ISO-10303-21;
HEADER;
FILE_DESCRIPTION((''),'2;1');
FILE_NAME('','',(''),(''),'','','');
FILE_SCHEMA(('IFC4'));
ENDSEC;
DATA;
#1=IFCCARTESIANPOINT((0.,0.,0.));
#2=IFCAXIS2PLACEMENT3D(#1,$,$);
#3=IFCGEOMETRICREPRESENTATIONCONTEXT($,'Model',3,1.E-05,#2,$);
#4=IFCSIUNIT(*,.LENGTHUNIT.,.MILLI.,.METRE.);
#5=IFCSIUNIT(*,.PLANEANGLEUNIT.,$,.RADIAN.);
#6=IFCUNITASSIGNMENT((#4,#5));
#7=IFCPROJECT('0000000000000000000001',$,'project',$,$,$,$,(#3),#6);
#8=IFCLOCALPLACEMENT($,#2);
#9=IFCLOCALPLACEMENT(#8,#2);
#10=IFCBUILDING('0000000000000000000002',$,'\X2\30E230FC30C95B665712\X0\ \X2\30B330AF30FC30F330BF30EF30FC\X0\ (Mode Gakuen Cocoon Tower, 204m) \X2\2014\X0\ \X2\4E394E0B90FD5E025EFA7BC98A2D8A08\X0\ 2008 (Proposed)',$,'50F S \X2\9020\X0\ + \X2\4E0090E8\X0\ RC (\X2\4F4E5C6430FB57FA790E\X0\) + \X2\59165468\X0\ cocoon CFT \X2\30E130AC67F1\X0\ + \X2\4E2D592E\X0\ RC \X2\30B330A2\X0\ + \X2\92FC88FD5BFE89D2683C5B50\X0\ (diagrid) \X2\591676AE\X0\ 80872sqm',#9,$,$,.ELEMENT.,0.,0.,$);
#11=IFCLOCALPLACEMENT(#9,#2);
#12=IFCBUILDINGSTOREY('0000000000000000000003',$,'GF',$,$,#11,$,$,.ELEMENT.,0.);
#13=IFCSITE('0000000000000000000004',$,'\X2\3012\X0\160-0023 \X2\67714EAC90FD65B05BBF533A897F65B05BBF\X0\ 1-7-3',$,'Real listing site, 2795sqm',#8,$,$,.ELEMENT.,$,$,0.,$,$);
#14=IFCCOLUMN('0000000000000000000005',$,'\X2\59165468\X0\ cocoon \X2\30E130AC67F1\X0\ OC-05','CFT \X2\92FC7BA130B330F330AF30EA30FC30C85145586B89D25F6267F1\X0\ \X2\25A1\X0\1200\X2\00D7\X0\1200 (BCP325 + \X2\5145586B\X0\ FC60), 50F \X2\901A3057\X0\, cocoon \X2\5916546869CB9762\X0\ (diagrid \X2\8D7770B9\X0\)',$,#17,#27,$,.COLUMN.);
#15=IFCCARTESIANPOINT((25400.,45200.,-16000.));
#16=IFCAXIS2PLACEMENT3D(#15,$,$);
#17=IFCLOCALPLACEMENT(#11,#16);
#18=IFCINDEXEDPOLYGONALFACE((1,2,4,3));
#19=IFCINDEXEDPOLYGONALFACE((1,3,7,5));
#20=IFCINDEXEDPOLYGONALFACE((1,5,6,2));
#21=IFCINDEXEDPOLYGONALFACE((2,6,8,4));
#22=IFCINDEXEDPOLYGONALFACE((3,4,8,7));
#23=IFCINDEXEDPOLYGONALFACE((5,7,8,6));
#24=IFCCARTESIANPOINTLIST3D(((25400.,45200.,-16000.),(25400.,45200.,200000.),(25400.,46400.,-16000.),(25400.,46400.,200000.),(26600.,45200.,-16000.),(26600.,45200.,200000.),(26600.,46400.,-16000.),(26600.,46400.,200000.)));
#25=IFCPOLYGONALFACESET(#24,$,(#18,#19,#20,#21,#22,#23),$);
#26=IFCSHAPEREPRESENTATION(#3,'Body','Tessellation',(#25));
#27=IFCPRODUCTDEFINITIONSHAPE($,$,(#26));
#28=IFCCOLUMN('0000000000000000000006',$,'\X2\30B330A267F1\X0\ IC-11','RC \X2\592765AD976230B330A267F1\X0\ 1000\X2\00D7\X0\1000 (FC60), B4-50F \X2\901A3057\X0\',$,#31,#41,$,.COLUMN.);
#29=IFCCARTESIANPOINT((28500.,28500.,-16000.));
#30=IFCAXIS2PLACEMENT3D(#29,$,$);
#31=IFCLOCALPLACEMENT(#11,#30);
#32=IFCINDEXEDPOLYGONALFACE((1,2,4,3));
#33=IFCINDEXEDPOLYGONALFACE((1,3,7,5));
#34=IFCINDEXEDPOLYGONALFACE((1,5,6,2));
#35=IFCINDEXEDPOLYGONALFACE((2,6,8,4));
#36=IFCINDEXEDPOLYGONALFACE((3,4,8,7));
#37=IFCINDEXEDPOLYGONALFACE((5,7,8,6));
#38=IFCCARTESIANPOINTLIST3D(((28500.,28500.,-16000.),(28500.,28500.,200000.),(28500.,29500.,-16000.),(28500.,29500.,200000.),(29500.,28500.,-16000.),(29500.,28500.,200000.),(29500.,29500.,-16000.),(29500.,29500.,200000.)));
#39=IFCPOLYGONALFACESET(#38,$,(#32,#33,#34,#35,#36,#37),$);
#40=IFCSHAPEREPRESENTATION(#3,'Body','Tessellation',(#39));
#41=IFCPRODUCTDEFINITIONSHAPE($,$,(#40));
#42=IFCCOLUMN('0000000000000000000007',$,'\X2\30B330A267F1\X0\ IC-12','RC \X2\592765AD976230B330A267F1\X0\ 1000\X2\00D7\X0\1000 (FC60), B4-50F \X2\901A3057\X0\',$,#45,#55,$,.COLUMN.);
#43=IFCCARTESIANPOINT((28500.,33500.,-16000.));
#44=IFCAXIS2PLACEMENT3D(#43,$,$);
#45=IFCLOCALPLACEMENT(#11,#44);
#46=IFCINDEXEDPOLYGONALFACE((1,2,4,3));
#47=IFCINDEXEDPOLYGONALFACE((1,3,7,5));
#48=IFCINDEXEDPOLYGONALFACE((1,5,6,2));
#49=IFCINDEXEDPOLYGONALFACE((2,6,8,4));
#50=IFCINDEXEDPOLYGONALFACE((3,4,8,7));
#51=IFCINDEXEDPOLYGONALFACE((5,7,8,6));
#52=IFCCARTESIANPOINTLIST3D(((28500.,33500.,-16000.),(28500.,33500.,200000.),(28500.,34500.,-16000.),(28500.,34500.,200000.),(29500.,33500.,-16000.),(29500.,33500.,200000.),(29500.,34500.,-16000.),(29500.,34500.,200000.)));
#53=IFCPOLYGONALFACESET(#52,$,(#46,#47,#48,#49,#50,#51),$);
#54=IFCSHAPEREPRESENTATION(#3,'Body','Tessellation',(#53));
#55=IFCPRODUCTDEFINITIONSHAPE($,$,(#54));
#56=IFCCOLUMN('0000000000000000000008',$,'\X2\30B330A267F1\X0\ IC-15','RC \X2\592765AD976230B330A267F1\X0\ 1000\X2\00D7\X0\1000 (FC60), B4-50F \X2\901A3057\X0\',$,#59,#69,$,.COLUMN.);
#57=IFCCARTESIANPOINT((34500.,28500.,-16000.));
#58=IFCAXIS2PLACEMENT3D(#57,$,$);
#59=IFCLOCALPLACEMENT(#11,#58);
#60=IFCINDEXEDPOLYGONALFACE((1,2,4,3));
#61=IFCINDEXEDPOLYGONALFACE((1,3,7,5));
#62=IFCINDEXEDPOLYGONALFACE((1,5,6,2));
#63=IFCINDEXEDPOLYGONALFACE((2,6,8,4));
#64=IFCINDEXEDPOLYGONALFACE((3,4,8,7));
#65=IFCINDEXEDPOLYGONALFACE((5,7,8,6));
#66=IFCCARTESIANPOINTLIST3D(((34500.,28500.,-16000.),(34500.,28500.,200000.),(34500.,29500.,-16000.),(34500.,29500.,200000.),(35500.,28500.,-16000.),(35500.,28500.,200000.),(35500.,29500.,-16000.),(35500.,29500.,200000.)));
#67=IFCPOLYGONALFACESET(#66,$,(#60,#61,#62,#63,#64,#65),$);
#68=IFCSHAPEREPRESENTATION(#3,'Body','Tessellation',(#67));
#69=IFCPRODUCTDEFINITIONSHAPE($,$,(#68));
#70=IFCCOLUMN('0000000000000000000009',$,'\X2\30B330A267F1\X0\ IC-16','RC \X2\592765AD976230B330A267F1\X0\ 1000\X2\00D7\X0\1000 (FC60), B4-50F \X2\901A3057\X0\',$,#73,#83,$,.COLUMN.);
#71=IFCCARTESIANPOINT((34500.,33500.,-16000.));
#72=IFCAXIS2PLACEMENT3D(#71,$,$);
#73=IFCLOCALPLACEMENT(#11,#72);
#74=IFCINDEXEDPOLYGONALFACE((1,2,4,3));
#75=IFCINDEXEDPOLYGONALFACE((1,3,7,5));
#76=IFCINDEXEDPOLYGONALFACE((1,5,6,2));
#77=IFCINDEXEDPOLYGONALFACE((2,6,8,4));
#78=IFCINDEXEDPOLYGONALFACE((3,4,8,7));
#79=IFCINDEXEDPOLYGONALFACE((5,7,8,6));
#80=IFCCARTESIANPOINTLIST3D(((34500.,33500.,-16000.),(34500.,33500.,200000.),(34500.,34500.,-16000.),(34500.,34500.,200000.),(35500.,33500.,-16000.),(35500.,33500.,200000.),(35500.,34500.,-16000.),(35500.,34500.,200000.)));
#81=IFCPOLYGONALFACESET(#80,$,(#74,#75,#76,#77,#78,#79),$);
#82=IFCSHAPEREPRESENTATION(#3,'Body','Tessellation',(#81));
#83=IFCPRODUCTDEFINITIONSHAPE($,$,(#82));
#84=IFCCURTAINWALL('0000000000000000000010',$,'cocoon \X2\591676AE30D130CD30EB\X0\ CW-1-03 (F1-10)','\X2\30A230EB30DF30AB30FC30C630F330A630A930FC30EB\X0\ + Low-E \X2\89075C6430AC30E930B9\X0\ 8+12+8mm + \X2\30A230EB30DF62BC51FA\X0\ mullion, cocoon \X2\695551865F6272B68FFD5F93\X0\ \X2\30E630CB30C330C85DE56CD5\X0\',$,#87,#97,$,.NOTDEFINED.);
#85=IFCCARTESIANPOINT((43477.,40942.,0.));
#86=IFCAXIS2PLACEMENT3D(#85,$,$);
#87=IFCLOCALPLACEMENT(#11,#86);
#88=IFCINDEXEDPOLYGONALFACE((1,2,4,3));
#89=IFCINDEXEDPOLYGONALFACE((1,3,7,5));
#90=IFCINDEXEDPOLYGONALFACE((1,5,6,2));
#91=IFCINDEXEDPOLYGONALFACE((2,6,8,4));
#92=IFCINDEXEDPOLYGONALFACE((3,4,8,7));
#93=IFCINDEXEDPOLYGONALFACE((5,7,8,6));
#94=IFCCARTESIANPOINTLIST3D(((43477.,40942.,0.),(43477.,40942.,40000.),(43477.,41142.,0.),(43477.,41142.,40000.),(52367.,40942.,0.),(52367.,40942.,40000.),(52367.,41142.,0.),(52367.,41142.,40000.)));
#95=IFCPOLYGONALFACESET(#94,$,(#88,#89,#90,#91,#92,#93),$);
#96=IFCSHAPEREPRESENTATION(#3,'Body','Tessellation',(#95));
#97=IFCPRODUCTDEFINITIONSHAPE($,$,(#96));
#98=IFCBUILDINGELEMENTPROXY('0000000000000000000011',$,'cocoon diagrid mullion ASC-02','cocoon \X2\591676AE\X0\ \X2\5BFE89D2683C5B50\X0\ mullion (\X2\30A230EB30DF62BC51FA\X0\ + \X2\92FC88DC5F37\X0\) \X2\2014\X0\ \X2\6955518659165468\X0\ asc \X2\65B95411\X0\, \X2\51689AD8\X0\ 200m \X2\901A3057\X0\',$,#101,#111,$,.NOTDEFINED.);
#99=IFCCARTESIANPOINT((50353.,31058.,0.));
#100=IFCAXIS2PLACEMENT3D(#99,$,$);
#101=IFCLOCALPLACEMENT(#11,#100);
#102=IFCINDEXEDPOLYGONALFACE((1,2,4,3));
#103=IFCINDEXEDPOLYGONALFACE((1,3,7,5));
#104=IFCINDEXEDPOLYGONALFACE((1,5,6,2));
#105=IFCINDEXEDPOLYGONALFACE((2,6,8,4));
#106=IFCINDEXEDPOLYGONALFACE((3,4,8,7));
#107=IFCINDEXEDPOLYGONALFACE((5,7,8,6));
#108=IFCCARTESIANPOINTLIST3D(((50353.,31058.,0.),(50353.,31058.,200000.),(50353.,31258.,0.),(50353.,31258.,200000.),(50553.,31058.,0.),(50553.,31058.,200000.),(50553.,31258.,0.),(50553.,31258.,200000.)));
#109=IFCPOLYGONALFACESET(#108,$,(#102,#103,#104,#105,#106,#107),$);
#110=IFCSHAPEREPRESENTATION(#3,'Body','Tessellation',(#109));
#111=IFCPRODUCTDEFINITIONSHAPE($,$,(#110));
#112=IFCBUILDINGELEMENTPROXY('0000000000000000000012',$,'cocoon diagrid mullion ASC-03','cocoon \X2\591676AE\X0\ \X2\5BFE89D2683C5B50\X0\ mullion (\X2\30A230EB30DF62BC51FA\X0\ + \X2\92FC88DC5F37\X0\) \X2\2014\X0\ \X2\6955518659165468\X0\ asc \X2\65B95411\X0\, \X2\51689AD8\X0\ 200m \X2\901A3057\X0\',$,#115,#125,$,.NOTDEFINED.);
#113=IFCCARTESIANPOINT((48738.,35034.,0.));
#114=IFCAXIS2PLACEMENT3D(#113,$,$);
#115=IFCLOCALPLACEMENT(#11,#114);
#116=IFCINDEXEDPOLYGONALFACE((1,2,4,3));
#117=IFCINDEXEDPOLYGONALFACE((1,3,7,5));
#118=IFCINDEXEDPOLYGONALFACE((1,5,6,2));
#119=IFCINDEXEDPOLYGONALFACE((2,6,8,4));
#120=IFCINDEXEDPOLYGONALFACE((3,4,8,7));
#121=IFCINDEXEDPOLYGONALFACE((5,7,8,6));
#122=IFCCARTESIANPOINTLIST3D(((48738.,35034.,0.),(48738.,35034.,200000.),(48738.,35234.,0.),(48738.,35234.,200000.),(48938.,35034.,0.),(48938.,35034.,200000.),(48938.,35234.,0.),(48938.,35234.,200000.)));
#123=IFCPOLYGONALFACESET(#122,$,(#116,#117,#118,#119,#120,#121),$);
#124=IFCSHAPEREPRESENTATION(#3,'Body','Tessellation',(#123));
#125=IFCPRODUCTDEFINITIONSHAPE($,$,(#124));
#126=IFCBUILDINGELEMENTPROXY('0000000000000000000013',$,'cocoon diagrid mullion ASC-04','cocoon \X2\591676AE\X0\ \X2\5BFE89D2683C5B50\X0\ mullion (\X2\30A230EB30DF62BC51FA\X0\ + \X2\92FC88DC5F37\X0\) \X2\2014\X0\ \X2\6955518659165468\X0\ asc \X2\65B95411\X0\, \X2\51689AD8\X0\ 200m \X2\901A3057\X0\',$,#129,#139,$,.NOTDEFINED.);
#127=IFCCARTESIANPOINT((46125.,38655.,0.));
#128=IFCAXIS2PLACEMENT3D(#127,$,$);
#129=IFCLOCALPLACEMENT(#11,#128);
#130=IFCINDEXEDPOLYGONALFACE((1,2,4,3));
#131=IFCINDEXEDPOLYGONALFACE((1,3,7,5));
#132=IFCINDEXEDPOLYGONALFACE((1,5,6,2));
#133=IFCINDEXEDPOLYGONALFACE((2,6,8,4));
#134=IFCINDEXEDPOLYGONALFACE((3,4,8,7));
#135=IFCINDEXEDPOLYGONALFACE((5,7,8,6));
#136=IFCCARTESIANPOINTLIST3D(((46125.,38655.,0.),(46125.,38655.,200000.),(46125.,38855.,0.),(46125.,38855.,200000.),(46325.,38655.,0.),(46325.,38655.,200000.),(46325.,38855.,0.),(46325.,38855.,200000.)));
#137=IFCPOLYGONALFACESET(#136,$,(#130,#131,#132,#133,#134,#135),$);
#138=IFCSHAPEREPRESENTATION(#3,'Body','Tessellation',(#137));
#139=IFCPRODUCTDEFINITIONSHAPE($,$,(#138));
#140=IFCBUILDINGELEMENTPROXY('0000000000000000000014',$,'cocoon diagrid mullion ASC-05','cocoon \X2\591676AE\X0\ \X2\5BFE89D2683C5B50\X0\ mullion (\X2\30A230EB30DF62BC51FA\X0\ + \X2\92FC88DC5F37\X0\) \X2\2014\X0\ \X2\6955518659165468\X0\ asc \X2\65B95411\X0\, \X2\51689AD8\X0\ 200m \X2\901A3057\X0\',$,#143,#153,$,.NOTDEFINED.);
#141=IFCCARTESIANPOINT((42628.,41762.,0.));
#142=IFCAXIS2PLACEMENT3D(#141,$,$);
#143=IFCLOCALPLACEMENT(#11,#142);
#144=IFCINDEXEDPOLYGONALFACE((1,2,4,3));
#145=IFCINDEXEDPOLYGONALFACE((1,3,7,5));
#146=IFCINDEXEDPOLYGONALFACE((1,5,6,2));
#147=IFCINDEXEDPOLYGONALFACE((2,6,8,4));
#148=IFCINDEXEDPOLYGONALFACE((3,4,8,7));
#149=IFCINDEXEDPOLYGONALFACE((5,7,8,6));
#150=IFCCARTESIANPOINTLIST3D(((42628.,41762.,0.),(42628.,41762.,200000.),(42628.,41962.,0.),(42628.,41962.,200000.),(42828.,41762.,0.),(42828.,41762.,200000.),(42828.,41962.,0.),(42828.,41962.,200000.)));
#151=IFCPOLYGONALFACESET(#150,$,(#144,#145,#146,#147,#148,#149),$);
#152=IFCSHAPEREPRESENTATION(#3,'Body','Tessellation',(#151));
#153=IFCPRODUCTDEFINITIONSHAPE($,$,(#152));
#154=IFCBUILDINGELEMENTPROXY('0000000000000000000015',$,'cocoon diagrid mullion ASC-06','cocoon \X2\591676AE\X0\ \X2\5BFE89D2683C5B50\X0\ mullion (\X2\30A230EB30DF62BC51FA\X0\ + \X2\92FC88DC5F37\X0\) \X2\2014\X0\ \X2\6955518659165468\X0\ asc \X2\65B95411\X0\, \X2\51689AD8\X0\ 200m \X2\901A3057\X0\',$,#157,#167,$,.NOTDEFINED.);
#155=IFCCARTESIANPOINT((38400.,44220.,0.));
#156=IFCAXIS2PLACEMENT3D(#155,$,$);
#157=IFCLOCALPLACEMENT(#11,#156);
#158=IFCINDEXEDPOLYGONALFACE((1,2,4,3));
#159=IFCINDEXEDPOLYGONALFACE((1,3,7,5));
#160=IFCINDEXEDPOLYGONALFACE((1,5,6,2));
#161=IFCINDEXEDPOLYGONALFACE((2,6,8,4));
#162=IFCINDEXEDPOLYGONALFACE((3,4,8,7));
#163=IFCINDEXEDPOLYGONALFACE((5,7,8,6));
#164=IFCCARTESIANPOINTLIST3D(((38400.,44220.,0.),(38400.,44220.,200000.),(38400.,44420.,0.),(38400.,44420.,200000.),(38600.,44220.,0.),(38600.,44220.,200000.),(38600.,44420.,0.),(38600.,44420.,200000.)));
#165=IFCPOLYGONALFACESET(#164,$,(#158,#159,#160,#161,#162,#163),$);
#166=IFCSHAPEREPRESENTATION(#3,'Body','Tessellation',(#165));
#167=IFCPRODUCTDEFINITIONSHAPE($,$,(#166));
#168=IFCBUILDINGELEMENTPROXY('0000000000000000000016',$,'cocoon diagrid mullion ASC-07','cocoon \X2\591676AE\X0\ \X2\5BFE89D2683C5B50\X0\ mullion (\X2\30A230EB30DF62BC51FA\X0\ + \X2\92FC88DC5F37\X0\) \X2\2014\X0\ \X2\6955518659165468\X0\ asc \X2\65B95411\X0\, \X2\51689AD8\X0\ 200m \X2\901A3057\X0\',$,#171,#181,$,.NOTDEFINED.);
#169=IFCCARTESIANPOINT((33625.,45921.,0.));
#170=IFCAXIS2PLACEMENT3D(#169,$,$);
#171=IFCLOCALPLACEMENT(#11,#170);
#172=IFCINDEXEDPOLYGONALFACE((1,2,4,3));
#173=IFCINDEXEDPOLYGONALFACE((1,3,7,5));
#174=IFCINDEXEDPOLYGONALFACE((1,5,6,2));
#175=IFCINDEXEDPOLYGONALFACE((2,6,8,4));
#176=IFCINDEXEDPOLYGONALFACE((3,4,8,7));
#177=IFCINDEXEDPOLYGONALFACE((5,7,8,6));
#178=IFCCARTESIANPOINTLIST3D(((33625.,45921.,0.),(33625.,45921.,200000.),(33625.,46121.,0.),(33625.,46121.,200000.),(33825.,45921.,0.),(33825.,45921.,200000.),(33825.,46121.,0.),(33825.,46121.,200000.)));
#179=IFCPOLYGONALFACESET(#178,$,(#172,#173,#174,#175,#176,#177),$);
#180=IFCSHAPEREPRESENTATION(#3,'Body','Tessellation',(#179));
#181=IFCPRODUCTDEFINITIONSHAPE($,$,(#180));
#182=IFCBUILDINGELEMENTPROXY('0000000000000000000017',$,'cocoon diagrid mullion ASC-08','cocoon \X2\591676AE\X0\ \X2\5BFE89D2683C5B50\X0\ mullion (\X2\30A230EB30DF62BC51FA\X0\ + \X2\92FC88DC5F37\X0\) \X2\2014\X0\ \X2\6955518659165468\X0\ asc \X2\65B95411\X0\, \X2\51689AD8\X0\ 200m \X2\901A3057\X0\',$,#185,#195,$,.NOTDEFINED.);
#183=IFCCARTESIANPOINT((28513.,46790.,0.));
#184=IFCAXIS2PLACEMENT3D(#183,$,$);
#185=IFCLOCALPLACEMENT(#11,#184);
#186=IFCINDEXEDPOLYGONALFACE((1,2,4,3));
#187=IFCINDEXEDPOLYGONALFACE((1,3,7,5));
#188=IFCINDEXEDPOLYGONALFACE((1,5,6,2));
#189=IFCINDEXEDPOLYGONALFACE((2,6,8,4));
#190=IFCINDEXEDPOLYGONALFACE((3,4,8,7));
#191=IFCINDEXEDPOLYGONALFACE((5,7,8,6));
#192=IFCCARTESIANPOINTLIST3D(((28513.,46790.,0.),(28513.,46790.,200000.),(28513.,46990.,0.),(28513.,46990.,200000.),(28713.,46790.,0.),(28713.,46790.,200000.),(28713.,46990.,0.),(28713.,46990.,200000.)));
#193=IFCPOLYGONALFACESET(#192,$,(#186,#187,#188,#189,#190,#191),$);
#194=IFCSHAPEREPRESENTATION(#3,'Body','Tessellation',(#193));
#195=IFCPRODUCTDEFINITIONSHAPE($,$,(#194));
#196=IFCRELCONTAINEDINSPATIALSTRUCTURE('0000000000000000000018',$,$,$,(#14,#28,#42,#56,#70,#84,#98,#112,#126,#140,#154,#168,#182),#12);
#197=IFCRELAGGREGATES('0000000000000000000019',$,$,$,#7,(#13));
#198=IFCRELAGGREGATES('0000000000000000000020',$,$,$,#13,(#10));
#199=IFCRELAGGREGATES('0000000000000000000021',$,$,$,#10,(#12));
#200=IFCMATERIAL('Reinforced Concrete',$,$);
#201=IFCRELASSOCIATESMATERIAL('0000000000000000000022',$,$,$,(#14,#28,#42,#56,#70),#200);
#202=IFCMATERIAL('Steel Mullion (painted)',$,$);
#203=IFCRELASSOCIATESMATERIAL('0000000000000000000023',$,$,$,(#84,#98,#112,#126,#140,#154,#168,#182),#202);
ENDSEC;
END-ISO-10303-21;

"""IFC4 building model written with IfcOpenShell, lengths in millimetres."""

from ifc_helpers import new_model, si_unit, frame, frame_2d, origin, place, context, project, spatial, rectangle, extrude, material, element, save


model = new_model("IFC4")

# Units and contexts
model_context = context("Model", 3, precision=1e-05, world=origin())
ifc_project = project(units=[si_unit("LENGTHUNIT", "METRE", prefix="MILLI"), si_unit("PLANEANGLEUNIT", "RADIAN")], contexts=[model_context])

# Site, building, storey
site_placement = place(None, origin())
site = spatial("IfcSite", under=ifc_project, at=site_placement, Name="〒160-0023 東京都新宿区西新宿 1-7-3", ObjectType="Real listing site, 2795sqm", CompositionType="ELEMENT", RefElevation=0.0)
building_placement = place(site_placement, origin())
building = spatial("IfcBuilding", under=site, at=building_placement, Name="モード学園 コクーンタワー (Mode Gakuen Cocoon Tower, 204m) — 丹下都市建築設計 2008 (Proposed)", ObjectType="50F S 造 + 一部 RC (低層・基礎) + 外周 cocoon CFT メガ柱 + 中央 RC コア + 鋼製対角格子 (diagrid) 外皮 80872sqm", CompositionType="ELEMENT", ElevationOfRefHeight=0.0, ElevationOfTerrain=0.0)
storey_placement = place(building_placement, origin())
storey = spatial("IfcBuildingStorey", under=building, at=storey_placement, Name="GF", CompositionType="ELEMENT", Elevation=0.0)

# Shared definitions
ifc_material_1 = material(Name="Reinforced Concrete")

# Columns
column_1_placement = place(storey_placement, frame((25400.0, 45200.0, -16000.0)))
element("IfcColumn", 1, at=column_1_placement, inside=storey, material=ifc_material_1, Name="外周 cocoon メガ柱 OC-05", Description="CFT 鋼管コンクリート充填角形柱 □1200×1200 (BCP325 + 充填 FC60), 50F 通し, cocoon 外周構面 (diagrid 起点)", PredefinedType="COLUMN", context=model_context, shape_type="SweptSolid", body=[
    extrude(rectangle(XDim=1200.0, YDim=1200.0, at=frame_2d((600.0, 600.0))), frame((25400.0, 45200.0, -16000.0)), (0.0, 0.0, 1.0), 216000.0),
])
column_2_placement = place(storey_placement, frame((28500.0, 28500.0, -16000.0)))
element("IfcColumn", 2, at=column_2_placement, inside=storey, material=ifc_material_1, Name="コア柱 IC-11", Description="RC 大断面コア柱 1000×1000 (FC60), B4-50F 通し", PredefinedType="COLUMN", context=model_context, shape_type="SweptSolid", body=[
    extrude(rectangle(XDim=1000.0, YDim=1000.0, at=frame_2d((500.0, 500.0))), frame((28500.0, 28500.0, -16000.0)), (0.0, 0.0, 1.0), 216000.0),
])
column_3_placement = place(storey_placement, frame((28500.0, 33500.0, -16000.0)))
element("IfcColumn", 3, at=column_3_placement, inside=storey, material=ifc_material_1, Name="コア柱 IC-12", Description="RC 大断面コア柱 1000×1000 (FC60), B4-50F 通し", PredefinedType="COLUMN", context=model_context, shape_type="SweptSolid", body=[
    extrude(rectangle(XDim=1000.0, YDim=1000.0, at=frame_2d((500.0, 500.0))), frame((28500.0, 33500.0, -16000.0)), (0.0, 0.0, 1.0), 216000.0),
])
column_4_placement = place(storey_placement, frame((34500.0, 28500.0, -16000.0)))
element("IfcColumn", 4, at=column_4_placement, inside=storey, material=ifc_material_1, Name="コア柱 IC-15", Description="RC 大断面コア柱 1000×1000 (FC60), B4-50F 通し", PredefinedType="COLUMN", context=model_context, shape_type="SweptSolid", body=[
    extrude(rectangle(XDim=1000.0, YDim=1000.0, at=frame_2d((500.0, 500.0))), frame((34500.0, 28500.0, -16000.0)), (0.0, 0.0, 1.0), 216000.0),
])
column_5_placement = place(storey_placement, frame((34500.0, 33500.0, -16000.0)))
element("IfcColumn", 5, at=column_5_placement, inside=storey, material=ifc_material_1, Name="コア柱 IC-16", Description="RC 大断面コア柱 1000×1000 (FC60), B4-50F 通し", PredefinedType="COLUMN", context=model_context, shape_type="SweptSolid", body=[
    extrude(rectangle(XDim=1000.0, YDim=1000.0, at=frame_2d((500.0, 500.0))), frame((34500.0, 33500.0, -16000.0)), (0.0, 0.0, 1.0), 216000.0),
])

# Curtain wall
ifc_material_2 = material(Name="Steel Mullion (painted)")
curtain_wall_1_placement = place(storey_placement, frame((43477.0, 40942.0, 0.0)))
element("IfcCurtainWall", 6, at=curtain_wall_1_placement, inside=storey, material=ifc_material_2, Name="cocoon 外皮パネル CW-1-03 (F1-10)", Description="アルミカーテンウォール + Low-E 複層ガラス 8+12+8mm + アルミ押出 mullion, cocoon 楕円形状追従 ユニット工法", PredefinedType="NOTDEFINED", context=model_context, shape_type="SweptSolid", body=[
    extrude(rectangle(XDim=8890.0, YDim=200.0, at=frame_2d((4445.0, 100.0))), frame((43477.0, 40942.0, 0.0)), (0.0, 0.0, 1.0), 40000.0),
])

# Building element proxies
proxy_1_placement = place(storey_placement, frame((50353.0, 31058.0, 0.0)))
element("IfcBuildingElementProxy", 7, at=proxy_1_placement, inside=storey, material=ifc_material_2, Name="cocoon diagrid mullion ASC-02", Description="cocoon 外皮 対角格子 mullion (アルミ押出 + 鋼補強) — 楕円外周 asc 方向, 全高 200m 通し", PredefinedType="NOTDEFINED", context=model_context, shape_type="SweptSolid", body=[
    extrude(rectangle(XDim=200.0, YDim=200.0, at=frame_2d((100.0, 100.0))), frame((50353.0, 31058.0, 0.0)), (0.0, 0.0, 1.0), 200000.0),
])
proxy_2_placement = place(storey_placement, frame((48738.0, 35034.0, 0.0)))
element("IfcBuildingElementProxy", 8, at=proxy_2_placement, inside=storey, material=ifc_material_2, Name="cocoon diagrid mullion ASC-03", Description="cocoon 外皮 対角格子 mullion (アルミ押出 + 鋼補強) — 楕円外周 asc 方向, 全高 200m 通し", PredefinedType="NOTDEFINED", context=model_context, shape_type="SweptSolid", body=[
    extrude(rectangle(XDim=200.0, YDim=200.0, at=frame_2d((100.0, 100.0))), frame((48738.0, 35034.0, 0.0)), (0.0, 0.0, 1.0), 200000.0),
])
proxy_3_placement = place(storey_placement, frame((46125.0, 38655.0, 0.0)))
element("IfcBuildingElementProxy", 9, at=proxy_3_placement, inside=storey, material=ifc_material_2, Name="cocoon diagrid mullion ASC-04", Description="cocoon 外皮 対角格子 mullion (アルミ押出 + 鋼補強) — 楕円外周 asc 方向, 全高 200m 通し", PredefinedType="NOTDEFINED", context=model_context, shape_type="SweptSolid", body=[
    extrude(rectangle(XDim=200.0, YDim=200.0, at=frame_2d((100.0, 100.0))), frame((46125.0, 38655.0, 0.0)), (0.0, 0.0, 1.0), 200000.0),
])
proxy_4_placement = place(storey_placement, frame((42628.0, 41762.0, 0.0)))
element("IfcBuildingElementProxy", 10, at=proxy_4_placement, inside=storey, material=ifc_material_2, Name="cocoon diagrid mullion ASC-05", Description="cocoon 外皮 対角格子 mullion (アルミ押出 + 鋼補強) — 楕円外周 asc 方向, 全高 200m 通し", PredefinedType="NOTDEFINED", context=model_context, shape_type="SweptSolid", body=[
    extrude(rectangle(XDim=200.0, YDim=200.0, at=frame_2d((100.0, 100.0))), frame((42628.0, 41762.0, 0.0)), (0.0, 0.0, 1.0), 200000.0),
])
proxy_5_placement = place(storey_placement, frame((38400.0, 44220.0, 0.0)))
element("IfcBuildingElementProxy", 11, at=proxy_5_placement, inside=storey, material=ifc_material_2, Name="cocoon diagrid mullion ASC-06", Description="cocoon 外皮 対角格子 mullion (アルミ押出 + 鋼補強) — 楕円外周 asc 方向, 全高 200m 通し", PredefinedType="NOTDEFINED", context=model_context, shape_type="SweptSolid", body=[
    extrude(rectangle(XDim=200.0, YDim=200.0, at=frame_2d((100.0, 100.0))), frame((38400.0, 44220.0, 0.0)), (0.0, 0.0, 1.0), 200000.0),
])
proxy_6_placement = place(storey_placement, frame((33625.0, 45921.0, 0.0)))
element("IfcBuildingElementProxy", 12, at=proxy_6_placement, inside=storey, material=ifc_material_2, Name="cocoon diagrid mullion ASC-07", Description="cocoon 外皮 対角格子 mullion (アルミ押出 + 鋼補強) — 楕円外周 asc 方向, 全高 200m 通し", PredefinedType="NOTDEFINED", context=model_context, shape_type="SweptSolid", body=[
    extrude(rectangle(XDim=200.0, YDim=200.0, at=frame_2d((100.0, 100.0))), frame((33625.0, 45921.0, 0.0)), (0.0, 0.0, 1.0), 200000.0),
])
proxy_7_placement = place(storey_placement, frame((28513.0, 46790.0, 0.0)))
element("IfcBuildingElementProxy", 13, at=proxy_7_placement, inside=storey, material=ifc_material_2, Name="cocoon diagrid mullion ASC-08", Description="cocoon 外皮 対角格子 mullion (アルミ押出 + 鋼補強) — 楕円外周 asc 方向, 全高 200m 通し", PredefinedType="NOTDEFINED", context=model_context, shape_type="SweptSolid", body=[
    extrude(rectangle(XDim=200.0, YDim=200.0, at=frame_2d((100.0, 100.0))), frame((28513.0, 46790.0, 0.0)), (0.0, 0.0, 1.0), 200000.0),
])

save(model, "model.ifc")
